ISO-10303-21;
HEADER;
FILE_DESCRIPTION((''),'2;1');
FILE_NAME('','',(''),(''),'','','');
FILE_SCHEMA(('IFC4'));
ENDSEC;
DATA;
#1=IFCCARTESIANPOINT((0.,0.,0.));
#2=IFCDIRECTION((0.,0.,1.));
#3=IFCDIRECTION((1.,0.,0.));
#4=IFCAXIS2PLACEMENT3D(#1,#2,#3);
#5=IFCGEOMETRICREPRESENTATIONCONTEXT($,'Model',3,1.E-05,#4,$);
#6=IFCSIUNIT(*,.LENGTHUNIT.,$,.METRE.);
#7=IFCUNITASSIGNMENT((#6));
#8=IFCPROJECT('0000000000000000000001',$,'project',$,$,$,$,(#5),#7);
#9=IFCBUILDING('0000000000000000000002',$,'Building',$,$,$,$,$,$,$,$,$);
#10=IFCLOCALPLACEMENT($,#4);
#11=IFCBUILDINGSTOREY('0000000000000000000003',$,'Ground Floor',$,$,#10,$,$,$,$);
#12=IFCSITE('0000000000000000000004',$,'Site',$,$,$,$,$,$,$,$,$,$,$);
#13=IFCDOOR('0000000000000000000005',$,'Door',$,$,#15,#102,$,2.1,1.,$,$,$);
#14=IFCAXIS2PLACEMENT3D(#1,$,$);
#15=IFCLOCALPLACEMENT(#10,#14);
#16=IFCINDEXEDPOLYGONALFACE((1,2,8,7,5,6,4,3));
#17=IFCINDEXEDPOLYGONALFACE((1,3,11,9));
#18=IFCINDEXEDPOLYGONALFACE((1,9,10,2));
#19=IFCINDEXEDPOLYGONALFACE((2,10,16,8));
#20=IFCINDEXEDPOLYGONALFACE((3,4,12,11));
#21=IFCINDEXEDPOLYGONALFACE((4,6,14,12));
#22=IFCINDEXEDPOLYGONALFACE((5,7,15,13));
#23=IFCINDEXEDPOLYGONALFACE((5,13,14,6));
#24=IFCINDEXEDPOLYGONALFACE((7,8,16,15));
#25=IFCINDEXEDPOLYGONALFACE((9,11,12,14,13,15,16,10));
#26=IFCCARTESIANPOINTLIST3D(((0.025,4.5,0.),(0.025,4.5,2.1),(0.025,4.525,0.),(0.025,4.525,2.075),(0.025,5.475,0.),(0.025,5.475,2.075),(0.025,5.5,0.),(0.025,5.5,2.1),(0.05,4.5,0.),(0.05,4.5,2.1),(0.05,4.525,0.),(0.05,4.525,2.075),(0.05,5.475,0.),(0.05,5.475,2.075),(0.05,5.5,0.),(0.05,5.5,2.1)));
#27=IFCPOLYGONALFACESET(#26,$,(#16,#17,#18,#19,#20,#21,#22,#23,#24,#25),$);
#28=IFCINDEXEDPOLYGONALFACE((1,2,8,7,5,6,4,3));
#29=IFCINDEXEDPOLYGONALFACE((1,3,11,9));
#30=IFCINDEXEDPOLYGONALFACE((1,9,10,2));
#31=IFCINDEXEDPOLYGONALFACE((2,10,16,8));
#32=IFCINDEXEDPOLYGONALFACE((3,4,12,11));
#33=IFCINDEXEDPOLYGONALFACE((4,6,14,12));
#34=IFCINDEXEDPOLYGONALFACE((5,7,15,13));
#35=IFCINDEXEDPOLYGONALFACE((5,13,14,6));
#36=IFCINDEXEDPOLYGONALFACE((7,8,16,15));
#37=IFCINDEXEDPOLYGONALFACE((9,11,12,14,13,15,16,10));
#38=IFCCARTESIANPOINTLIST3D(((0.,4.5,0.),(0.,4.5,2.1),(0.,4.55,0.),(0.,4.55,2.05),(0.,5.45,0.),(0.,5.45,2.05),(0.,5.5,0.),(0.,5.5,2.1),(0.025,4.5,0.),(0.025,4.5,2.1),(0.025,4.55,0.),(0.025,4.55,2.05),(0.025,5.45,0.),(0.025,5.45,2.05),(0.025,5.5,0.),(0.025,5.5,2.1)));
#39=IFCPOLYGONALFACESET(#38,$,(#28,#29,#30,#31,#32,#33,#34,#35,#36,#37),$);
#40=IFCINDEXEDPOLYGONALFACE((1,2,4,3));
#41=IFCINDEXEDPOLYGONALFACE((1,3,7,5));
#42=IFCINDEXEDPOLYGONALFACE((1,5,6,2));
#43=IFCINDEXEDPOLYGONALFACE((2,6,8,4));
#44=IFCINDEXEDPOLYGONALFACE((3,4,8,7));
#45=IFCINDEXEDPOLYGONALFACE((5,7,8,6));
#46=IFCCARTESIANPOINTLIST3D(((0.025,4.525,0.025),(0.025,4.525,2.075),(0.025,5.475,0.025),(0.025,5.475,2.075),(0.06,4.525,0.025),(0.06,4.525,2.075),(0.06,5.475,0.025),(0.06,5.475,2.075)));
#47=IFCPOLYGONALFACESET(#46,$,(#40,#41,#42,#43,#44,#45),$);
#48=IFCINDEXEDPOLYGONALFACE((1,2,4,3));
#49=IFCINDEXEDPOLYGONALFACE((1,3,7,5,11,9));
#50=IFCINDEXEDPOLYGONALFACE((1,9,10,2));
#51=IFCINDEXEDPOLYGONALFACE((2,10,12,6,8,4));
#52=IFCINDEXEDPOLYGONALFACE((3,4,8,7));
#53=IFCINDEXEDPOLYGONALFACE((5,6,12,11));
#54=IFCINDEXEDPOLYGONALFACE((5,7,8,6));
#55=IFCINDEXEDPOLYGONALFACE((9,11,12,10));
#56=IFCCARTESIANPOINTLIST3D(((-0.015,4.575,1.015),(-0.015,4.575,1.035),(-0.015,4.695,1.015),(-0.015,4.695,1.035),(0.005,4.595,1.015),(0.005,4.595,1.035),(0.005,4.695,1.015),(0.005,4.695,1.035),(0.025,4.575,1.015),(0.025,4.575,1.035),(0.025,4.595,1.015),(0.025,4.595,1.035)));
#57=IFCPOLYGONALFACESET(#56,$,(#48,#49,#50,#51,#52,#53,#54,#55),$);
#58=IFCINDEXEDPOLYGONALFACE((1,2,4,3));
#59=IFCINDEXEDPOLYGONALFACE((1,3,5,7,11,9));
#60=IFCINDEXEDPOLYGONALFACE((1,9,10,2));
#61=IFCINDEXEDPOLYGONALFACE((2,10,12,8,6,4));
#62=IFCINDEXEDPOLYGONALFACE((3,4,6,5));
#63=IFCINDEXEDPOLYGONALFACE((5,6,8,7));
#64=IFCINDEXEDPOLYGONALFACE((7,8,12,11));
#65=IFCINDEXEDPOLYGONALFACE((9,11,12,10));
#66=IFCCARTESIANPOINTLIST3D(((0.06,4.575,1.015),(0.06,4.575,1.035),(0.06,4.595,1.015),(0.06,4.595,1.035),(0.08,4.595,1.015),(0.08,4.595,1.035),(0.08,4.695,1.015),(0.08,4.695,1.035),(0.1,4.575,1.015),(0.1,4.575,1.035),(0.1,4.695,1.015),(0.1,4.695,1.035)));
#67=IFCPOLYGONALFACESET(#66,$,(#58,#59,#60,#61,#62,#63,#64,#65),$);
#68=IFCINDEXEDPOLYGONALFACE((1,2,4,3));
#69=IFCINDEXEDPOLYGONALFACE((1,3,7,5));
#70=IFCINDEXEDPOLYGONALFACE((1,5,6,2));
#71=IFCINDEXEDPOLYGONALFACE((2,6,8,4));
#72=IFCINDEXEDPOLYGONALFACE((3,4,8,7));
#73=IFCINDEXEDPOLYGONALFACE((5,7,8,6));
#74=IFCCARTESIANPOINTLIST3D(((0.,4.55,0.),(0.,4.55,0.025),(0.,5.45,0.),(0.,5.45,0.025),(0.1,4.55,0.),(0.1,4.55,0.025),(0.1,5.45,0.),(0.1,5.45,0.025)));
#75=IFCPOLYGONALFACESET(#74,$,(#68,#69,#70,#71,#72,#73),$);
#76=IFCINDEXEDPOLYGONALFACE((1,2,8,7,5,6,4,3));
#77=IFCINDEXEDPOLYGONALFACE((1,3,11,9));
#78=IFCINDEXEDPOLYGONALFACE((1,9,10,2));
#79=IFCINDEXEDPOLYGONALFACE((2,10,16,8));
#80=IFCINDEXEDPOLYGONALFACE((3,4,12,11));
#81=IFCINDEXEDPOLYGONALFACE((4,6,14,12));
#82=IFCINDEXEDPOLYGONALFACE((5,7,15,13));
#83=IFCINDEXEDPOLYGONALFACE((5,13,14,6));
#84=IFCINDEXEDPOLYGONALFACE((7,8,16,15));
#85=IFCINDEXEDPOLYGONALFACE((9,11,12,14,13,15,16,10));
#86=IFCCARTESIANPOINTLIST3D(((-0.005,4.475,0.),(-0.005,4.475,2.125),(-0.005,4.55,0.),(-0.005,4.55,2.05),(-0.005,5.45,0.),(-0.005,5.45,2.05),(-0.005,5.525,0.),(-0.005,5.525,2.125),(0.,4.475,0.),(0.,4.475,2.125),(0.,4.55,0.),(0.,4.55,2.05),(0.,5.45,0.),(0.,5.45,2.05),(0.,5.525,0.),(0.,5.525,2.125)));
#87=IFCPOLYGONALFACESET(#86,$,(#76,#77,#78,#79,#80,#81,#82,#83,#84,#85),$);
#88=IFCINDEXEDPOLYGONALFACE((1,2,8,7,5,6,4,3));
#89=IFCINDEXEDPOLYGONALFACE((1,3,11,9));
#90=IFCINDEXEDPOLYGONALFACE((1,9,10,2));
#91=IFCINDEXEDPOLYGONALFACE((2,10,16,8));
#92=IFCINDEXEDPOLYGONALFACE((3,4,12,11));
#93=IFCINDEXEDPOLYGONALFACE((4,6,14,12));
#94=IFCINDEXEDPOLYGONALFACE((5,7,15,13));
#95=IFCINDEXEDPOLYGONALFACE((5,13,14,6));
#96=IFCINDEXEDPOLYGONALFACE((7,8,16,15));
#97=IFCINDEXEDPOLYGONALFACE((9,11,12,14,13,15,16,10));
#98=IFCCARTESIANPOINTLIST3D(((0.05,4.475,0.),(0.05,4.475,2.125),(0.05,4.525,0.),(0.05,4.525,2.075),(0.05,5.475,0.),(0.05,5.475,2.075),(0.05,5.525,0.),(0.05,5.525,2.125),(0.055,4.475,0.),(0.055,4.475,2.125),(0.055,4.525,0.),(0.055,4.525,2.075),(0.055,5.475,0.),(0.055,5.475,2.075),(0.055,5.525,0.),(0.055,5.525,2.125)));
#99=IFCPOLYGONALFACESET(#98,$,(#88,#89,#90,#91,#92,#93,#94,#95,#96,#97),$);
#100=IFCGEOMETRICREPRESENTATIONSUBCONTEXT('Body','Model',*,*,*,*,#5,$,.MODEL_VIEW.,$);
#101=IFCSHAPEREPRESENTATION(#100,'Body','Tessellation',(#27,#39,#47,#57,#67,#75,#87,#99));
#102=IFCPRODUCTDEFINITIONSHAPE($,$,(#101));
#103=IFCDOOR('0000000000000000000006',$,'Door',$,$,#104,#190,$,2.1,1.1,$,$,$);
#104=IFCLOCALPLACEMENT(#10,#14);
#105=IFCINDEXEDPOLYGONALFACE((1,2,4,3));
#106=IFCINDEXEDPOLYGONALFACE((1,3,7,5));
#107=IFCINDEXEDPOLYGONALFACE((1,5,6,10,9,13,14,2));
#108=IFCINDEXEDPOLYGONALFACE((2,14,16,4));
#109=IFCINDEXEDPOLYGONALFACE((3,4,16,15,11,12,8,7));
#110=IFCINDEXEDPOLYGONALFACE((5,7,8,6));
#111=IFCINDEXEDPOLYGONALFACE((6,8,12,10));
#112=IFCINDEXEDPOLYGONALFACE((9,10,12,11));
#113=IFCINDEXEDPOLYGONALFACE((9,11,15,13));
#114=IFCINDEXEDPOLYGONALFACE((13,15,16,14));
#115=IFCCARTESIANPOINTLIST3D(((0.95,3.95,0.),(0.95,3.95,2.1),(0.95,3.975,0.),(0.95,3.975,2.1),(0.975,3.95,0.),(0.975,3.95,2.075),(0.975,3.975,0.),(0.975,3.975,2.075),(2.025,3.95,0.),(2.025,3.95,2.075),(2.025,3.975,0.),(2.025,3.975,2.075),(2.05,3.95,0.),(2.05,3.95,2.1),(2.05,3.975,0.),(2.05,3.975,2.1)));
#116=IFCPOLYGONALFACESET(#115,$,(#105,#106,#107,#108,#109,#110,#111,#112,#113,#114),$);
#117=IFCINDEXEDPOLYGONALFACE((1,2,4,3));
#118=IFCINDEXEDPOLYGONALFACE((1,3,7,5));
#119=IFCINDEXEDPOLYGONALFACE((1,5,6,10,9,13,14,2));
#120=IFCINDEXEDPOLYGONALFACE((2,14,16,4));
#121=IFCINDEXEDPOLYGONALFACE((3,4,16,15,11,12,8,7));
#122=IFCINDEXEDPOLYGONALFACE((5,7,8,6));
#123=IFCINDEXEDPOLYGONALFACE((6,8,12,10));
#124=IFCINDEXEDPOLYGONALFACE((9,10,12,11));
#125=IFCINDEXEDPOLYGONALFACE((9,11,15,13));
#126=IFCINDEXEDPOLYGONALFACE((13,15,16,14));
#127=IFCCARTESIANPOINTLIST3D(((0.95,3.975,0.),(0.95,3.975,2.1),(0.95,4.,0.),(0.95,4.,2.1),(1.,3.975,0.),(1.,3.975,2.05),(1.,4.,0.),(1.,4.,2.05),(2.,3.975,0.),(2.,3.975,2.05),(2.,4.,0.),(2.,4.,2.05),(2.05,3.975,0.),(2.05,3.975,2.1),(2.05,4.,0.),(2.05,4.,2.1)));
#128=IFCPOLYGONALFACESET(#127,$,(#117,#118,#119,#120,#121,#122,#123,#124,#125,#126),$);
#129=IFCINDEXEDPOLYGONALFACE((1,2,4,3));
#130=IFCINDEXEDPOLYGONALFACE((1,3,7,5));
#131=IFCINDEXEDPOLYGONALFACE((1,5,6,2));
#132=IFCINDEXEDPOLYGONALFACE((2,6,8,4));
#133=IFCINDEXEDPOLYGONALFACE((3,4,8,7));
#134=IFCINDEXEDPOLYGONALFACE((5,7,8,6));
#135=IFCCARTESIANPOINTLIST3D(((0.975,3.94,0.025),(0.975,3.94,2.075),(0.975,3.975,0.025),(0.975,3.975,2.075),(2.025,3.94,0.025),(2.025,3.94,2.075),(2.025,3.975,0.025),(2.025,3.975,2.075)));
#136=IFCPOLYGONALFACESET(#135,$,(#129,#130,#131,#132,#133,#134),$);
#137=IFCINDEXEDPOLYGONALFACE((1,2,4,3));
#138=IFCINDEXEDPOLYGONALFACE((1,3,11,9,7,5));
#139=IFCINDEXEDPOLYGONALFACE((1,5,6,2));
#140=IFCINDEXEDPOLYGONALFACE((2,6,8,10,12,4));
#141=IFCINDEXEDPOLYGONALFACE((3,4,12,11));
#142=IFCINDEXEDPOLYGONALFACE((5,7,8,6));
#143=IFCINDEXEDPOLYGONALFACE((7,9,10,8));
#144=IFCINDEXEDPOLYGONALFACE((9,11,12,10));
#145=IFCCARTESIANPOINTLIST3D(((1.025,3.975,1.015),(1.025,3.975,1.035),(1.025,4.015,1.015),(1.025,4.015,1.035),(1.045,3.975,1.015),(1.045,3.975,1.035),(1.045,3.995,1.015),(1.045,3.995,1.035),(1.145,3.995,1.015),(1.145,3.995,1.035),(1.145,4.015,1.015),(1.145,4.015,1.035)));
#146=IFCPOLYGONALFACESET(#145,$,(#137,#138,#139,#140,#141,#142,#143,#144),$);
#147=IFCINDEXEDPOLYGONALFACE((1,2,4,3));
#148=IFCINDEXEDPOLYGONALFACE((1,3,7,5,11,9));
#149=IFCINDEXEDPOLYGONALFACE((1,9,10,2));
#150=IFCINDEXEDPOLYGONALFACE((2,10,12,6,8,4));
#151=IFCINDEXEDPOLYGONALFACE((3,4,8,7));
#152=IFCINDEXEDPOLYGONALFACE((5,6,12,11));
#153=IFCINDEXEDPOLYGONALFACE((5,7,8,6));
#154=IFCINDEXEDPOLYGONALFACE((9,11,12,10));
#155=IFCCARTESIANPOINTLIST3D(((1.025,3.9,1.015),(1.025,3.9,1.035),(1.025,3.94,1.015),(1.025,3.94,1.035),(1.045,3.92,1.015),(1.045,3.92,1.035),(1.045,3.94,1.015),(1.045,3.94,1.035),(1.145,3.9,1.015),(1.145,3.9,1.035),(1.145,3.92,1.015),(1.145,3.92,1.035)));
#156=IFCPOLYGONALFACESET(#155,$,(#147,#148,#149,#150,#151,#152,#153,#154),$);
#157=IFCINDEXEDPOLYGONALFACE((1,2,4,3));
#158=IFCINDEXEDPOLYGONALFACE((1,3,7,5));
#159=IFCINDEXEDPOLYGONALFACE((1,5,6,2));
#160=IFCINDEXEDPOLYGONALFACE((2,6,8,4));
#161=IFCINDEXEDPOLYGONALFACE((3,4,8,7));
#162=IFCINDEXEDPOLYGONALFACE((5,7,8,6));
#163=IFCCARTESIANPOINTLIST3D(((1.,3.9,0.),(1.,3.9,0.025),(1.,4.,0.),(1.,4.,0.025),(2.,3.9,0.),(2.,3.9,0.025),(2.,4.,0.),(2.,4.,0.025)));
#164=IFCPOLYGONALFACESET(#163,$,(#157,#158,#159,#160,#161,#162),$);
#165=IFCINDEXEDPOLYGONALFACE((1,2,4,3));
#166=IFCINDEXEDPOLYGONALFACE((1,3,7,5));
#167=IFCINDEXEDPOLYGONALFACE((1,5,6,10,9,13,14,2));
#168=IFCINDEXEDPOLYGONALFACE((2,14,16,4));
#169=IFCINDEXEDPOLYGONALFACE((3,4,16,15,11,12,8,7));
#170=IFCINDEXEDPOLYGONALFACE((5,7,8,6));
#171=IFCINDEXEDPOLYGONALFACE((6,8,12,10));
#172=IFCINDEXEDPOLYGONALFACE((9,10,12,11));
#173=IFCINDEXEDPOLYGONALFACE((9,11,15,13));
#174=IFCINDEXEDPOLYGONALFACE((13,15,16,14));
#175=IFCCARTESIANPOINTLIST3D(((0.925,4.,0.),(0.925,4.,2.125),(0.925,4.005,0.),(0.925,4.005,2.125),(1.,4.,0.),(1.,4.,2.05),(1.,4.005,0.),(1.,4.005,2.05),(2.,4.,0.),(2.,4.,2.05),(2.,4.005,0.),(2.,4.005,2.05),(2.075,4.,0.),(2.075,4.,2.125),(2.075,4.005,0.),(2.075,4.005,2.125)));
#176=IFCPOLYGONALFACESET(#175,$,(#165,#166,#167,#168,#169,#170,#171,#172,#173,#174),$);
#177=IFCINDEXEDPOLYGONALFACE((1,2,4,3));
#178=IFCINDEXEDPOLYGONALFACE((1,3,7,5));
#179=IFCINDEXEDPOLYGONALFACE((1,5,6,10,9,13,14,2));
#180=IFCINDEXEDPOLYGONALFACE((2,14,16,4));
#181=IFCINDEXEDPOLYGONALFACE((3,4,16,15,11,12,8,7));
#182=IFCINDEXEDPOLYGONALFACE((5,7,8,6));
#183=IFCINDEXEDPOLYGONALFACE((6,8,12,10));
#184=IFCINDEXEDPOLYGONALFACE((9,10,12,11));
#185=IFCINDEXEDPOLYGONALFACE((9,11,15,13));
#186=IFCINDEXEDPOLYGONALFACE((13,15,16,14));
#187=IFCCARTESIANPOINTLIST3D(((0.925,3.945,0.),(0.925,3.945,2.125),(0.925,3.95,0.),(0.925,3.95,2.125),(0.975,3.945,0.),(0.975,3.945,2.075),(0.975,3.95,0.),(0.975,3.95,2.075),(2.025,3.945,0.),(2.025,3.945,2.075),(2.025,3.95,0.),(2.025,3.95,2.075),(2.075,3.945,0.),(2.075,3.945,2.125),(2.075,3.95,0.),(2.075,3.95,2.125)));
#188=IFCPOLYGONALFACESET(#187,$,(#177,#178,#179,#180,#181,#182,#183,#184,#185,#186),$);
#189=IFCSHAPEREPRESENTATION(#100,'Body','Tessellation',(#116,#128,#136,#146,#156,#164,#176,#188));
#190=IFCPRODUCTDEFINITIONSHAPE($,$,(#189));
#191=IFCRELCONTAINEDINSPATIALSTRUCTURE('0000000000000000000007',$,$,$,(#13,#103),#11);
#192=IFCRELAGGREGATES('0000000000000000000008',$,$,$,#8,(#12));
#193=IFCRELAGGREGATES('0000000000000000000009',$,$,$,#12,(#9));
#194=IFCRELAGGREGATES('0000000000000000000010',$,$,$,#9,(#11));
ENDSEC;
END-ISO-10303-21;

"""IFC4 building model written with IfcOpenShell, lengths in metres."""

from ifc_helpers import new_model, si_unit, frame, origin_with_axes, place, context, subcontext, project, spatial, line, indexed_curve, outline, extrude, element, save


model = new_model("IFC4")

# Units and contexts
model_context = context("Model", 3, precision=1e-05, world=origin_with_axes())
body_context = subcontext(model_context, "Body", "Model", "MODEL_VIEW")
ifc_project = project(units=[si_unit("LENGTHUNIT", "METRE")], contexts=[model_context])

# Site, building, storey
site = spatial("IfcSite", under=ifc_project, Name="Site")
building = spatial("IfcBuilding", under=site, Name="Building")
storey_placement = place(None, origin_with_axes())
storey = spatial("IfcBuildingStorey", under=building, at=storey_placement, Name="Ground Floor")

# Doors
door_1_placement = place(storey_placement, frame((0.0, 5.5, 0.0), z_axis=(0.0, 0.0, 1.0), x_axis=(0.0, -1.0, 0.0)))
element("IfcDoor", 1, at=door_1_placement, inside=storey, Name="Door", OverallHeight=2.1, OverallWidth=1.0, context=body_context, shape_type="SweptSolid", body=[
    extrude(outline(indexed_curve([(0.0, 0.0), (0.0, 2.1), (1.0, 2.1), (1.0, 0.0), (0.975, 0.0), (0.975, 2.075), (0.025, 2.075), (0.025, 0.0)], segments=[line(1, 2, 3, 4, 5, 6, 7, 8, 1)])), frame((0.0, 0.025, 0.0), z_axis=(0.0, -1.0, 0.0), x_axis=(1.0, 0.0, 0.0)), (0.0, 0.0, -1.0), 0.025),
    extrude(outline(indexed_curve([(0.0, 0.0), (0.0, 2.1), (1.0, 2.1), (1.0, 0.0), (0.95, 0.0), (0.95, 2.05), (0.05, 2.05), (0.05, 0.0)], segments=[line(1, 2, 3, 4, 5, 6, 7, 8, 1)])), frame((0.0, 0.0, 0.0), z_axis=(0.0, -1.0, 0.0), x_axis=(1.0, 0.0, 0.0)), (0.0, 0.0, -1.0), 0.025),
    extrude(outline(indexed_curve([(0.0, 0.0), (0.95, 0.0), (0.95, 0.035), (0.0, 0.035)], segments=[line(1, 2, 3, 4, 1)])), frame((0.025, 0.025, 0.025), z_axis=(0.0, 0.0, 1.0), x_axis=(1.0, 0.0, 0.0)), (0.0, 0.0, 1.0), 2.05),
    extrude(outline(indexed_curve([(0.0, 0.0), (0.0, -0.04), (-0.12, -0.04), (-0.12, -0.02), (-0.02, -0.02), (-0.02, 0.0)], segments=[line(1, 2, 3, 4, 5, 6, 1)])), frame((0.925, 0.025, 1.015), z_axis=(0.0, 0.0, 1.0), x_axis=(1.0, 0.0, 0.0)), (0.0, 0.0, 1.0), 0.02),
    extrude(outline(indexed_curve([(0.0, 0.0), (0.0, 0.04), (-0.12, 0.04), (-0.12, 0.02), (-0.02, 0.02), (-0.02, 0.0)], segments=[line(1, 2, 3, 4, 5, 6, 1)])), frame((0.925, 0.06, 1.015), z_axis=(0.0, 0.0, 1.0), x_axis=(1.0, 0.0, 0.0)), (0.0, 0.0, 1.0), 0.02),
    extrude(outline(indexed_curve([(0.0, 0.0), (0.9, 0.0), (0.9, 0.1), (0.0, 0.1)], segments=[line(1, 2, 3, 4, 1)])), frame((0.05, 0.0, 0.0), z_axis=(0.0, 0.0, 1.0), x_axis=(1.0, 0.0, 0.0)), (0.0, 0.0, 1.0), 0.025),
    extrude(outline(indexed_curve([(0.0, 0.0), (0.0, 2.125), (1.05, 2.125), (1.05, 0.0), (0.975, 0.0), (0.975, 2.05), (0.075, 2.05), (0.075, 0.0)], segments=[line(1, 2, 3, 4, 5, 6, 7, 8, 1)])), frame((-0.025, -0.005, 0.0), z_axis=(0.0, -1.0, 0.0), x_axis=(1.0, 0.0, 0.0)), (0.0, 0.0, -1.0), 0.005),
    extrude(outline(indexed_curve([(0.0, 0.0), (0.0, 2.125), (1.05, 2.125), (1.05, 0.0), (1.0, 0.0), (1.0, 2.075), (0.05, 2.075), (0.05, 0.0)], segments=[line(1, 2, 3, 4, 5, 6, 7, 8, 1)])), frame((-0.025, 0.05, 0.0), z_axis=(0.0, -1.0, 0.0), x_axis=(1.0, 0.0, 0.0)), (0.0, 0.0, -1.0), 0.005),
])
door_2_placement = place(storey_placement, frame((2.05, 4.0, 0.0), z_axis=(0.0, 0.0, 1.0), x_axis=(-1.0, 0.0, 0.0)))
element("IfcDoor", 2, at=door_2_placement, inside=storey, Name="Door", OverallHeight=2.1, OverallWidth=1.1, context=body_context, shape_type="SweptSolid", body=[
    extrude(outline(indexed_curve([(0.0, 0.0), (0.0, 2.1), (1.1, 2.1), (1.1, 0.0), (1.075, 0.0), (1.075, 2.075), (0.025, 2.075), (0.025, 0.0)], segments=[line(1, 2, 3, 4, 5, 6, 7, 8, 1)])), frame((0.0, 0.025, 0.0), z_axis=(0.0, -1.0, 0.0), x_axis=(1.0, 0.0, 0.0)), (0.0, 0.0, -1.0), 0.025),
    extrude(outline(indexed_curve([(0.0, 0.0), (0.0, 2.1), (1.1, 2.1), (1.1, 0.0), (1.05, 0.0), (1.05, 2.05), (0.05, 2.05), (0.05, 0.0)], segments=[line(1, 2, 3, 4, 5, 6, 7, 8, 1)])), frame((0.0, 0.0, 0.0), z_axis=(0.0, -1.0, 0.0), x_axis=(1.0, 0.0, 0.0)), (0.0, 0.0, -1.0), 0.025),
    extrude(outline(indexed_curve([(0.0, 0.0), (1.05, 0.0), (1.05, 0.035), (0.0, 0.035)], segments=[line(1, 2, 3, 4, 1)])), frame((0.025, 0.025, 0.025), z_axis=(0.0, 0.0, 1.0), x_axis=(1.0, 0.0, 0.0)), (0.0, 0.0, 1.0), 2.05),
    extrude(outline(indexed_curve([(0.0, 0.0), (0.0, -0.04), (-0.12, -0.04), (-0.12, -0.02), (-0.02, -0.02), (-0.02, 0.0)], segments=[line(1, 2, 3, 4, 5, 6, 1)])), frame((1.025, 0.025, 1.015), z_axis=(0.0, 0.0, 1.0), x_axis=(1.0, 0.0, 0.0)), (0.0, 0.0, 1.0), 0.02),
    extrude(outline(indexed_curve([(0.0, 0.0), (0.0, 0.04), (-0.12, 0.04), (-0.12, 0.02), (-0.02, 0.02), (-0.02, 0.0)], segments=[line(1, 2, 3, 4, 5, 6, 1)])), frame((1.025, 0.06, 1.015), z_axis=(0.0, 0.0, 1.0), x_axis=(1.0, 0.0, 0.0)), (0.0, 0.0, 1.0), 0.02),
    extrude(outline(indexed_curve([(0.0, 0.0), (1.0, 0.0), (1.0, 0.1), (0.0, 0.1)], segments=[line(1, 2, 3, 4, 1)])), frame((0.05, 0.0, 0.0), z_axis=(0.0, 0.0, 1.0), x_axis=(1.0, 0.0, 0.0)), (0.0, 0.0, 1.0), 0.025),
    extrude(outline(indexed_curve([(0.0, 0.0), (0.0, 2.125), (1.15, 2.125), (1.15, 0.0), (1.075, 0.0), (1.075, 2.05), (0.075, 2.05), (0.075, 0.0)], segments=[line(1, 2, 3, 4, 5, 6, 7, 8, 1)])), frame((-0.025, -0.005, 0.0), z_axis=(0.0, -1.0, 0.0), x_axis=(1.0, 0.0, 0.0)), (0.0, 0.0, -1.0), 0.005),
    extrude(outline(indexed_curve([(0.0, 0.0), (0.0, 2.125), (1.15, 2.125), (1.15, 0.0), (1.1, 0.0), (1.1, 2.075), (0.05, 2.075), (0.05, 0.0)], segments=[line(1, 2, 3, 4, 5, 6, 7, 8, 1)])), frame((-0.025, 0.05, 0.0), z_axis=(0.0, -1.0, 0.0), x_axis=(1.0, 0.0, 0.0)), (0.0, 0.0, -1.0), 0.005),
])

save(model, "model.ifc")
